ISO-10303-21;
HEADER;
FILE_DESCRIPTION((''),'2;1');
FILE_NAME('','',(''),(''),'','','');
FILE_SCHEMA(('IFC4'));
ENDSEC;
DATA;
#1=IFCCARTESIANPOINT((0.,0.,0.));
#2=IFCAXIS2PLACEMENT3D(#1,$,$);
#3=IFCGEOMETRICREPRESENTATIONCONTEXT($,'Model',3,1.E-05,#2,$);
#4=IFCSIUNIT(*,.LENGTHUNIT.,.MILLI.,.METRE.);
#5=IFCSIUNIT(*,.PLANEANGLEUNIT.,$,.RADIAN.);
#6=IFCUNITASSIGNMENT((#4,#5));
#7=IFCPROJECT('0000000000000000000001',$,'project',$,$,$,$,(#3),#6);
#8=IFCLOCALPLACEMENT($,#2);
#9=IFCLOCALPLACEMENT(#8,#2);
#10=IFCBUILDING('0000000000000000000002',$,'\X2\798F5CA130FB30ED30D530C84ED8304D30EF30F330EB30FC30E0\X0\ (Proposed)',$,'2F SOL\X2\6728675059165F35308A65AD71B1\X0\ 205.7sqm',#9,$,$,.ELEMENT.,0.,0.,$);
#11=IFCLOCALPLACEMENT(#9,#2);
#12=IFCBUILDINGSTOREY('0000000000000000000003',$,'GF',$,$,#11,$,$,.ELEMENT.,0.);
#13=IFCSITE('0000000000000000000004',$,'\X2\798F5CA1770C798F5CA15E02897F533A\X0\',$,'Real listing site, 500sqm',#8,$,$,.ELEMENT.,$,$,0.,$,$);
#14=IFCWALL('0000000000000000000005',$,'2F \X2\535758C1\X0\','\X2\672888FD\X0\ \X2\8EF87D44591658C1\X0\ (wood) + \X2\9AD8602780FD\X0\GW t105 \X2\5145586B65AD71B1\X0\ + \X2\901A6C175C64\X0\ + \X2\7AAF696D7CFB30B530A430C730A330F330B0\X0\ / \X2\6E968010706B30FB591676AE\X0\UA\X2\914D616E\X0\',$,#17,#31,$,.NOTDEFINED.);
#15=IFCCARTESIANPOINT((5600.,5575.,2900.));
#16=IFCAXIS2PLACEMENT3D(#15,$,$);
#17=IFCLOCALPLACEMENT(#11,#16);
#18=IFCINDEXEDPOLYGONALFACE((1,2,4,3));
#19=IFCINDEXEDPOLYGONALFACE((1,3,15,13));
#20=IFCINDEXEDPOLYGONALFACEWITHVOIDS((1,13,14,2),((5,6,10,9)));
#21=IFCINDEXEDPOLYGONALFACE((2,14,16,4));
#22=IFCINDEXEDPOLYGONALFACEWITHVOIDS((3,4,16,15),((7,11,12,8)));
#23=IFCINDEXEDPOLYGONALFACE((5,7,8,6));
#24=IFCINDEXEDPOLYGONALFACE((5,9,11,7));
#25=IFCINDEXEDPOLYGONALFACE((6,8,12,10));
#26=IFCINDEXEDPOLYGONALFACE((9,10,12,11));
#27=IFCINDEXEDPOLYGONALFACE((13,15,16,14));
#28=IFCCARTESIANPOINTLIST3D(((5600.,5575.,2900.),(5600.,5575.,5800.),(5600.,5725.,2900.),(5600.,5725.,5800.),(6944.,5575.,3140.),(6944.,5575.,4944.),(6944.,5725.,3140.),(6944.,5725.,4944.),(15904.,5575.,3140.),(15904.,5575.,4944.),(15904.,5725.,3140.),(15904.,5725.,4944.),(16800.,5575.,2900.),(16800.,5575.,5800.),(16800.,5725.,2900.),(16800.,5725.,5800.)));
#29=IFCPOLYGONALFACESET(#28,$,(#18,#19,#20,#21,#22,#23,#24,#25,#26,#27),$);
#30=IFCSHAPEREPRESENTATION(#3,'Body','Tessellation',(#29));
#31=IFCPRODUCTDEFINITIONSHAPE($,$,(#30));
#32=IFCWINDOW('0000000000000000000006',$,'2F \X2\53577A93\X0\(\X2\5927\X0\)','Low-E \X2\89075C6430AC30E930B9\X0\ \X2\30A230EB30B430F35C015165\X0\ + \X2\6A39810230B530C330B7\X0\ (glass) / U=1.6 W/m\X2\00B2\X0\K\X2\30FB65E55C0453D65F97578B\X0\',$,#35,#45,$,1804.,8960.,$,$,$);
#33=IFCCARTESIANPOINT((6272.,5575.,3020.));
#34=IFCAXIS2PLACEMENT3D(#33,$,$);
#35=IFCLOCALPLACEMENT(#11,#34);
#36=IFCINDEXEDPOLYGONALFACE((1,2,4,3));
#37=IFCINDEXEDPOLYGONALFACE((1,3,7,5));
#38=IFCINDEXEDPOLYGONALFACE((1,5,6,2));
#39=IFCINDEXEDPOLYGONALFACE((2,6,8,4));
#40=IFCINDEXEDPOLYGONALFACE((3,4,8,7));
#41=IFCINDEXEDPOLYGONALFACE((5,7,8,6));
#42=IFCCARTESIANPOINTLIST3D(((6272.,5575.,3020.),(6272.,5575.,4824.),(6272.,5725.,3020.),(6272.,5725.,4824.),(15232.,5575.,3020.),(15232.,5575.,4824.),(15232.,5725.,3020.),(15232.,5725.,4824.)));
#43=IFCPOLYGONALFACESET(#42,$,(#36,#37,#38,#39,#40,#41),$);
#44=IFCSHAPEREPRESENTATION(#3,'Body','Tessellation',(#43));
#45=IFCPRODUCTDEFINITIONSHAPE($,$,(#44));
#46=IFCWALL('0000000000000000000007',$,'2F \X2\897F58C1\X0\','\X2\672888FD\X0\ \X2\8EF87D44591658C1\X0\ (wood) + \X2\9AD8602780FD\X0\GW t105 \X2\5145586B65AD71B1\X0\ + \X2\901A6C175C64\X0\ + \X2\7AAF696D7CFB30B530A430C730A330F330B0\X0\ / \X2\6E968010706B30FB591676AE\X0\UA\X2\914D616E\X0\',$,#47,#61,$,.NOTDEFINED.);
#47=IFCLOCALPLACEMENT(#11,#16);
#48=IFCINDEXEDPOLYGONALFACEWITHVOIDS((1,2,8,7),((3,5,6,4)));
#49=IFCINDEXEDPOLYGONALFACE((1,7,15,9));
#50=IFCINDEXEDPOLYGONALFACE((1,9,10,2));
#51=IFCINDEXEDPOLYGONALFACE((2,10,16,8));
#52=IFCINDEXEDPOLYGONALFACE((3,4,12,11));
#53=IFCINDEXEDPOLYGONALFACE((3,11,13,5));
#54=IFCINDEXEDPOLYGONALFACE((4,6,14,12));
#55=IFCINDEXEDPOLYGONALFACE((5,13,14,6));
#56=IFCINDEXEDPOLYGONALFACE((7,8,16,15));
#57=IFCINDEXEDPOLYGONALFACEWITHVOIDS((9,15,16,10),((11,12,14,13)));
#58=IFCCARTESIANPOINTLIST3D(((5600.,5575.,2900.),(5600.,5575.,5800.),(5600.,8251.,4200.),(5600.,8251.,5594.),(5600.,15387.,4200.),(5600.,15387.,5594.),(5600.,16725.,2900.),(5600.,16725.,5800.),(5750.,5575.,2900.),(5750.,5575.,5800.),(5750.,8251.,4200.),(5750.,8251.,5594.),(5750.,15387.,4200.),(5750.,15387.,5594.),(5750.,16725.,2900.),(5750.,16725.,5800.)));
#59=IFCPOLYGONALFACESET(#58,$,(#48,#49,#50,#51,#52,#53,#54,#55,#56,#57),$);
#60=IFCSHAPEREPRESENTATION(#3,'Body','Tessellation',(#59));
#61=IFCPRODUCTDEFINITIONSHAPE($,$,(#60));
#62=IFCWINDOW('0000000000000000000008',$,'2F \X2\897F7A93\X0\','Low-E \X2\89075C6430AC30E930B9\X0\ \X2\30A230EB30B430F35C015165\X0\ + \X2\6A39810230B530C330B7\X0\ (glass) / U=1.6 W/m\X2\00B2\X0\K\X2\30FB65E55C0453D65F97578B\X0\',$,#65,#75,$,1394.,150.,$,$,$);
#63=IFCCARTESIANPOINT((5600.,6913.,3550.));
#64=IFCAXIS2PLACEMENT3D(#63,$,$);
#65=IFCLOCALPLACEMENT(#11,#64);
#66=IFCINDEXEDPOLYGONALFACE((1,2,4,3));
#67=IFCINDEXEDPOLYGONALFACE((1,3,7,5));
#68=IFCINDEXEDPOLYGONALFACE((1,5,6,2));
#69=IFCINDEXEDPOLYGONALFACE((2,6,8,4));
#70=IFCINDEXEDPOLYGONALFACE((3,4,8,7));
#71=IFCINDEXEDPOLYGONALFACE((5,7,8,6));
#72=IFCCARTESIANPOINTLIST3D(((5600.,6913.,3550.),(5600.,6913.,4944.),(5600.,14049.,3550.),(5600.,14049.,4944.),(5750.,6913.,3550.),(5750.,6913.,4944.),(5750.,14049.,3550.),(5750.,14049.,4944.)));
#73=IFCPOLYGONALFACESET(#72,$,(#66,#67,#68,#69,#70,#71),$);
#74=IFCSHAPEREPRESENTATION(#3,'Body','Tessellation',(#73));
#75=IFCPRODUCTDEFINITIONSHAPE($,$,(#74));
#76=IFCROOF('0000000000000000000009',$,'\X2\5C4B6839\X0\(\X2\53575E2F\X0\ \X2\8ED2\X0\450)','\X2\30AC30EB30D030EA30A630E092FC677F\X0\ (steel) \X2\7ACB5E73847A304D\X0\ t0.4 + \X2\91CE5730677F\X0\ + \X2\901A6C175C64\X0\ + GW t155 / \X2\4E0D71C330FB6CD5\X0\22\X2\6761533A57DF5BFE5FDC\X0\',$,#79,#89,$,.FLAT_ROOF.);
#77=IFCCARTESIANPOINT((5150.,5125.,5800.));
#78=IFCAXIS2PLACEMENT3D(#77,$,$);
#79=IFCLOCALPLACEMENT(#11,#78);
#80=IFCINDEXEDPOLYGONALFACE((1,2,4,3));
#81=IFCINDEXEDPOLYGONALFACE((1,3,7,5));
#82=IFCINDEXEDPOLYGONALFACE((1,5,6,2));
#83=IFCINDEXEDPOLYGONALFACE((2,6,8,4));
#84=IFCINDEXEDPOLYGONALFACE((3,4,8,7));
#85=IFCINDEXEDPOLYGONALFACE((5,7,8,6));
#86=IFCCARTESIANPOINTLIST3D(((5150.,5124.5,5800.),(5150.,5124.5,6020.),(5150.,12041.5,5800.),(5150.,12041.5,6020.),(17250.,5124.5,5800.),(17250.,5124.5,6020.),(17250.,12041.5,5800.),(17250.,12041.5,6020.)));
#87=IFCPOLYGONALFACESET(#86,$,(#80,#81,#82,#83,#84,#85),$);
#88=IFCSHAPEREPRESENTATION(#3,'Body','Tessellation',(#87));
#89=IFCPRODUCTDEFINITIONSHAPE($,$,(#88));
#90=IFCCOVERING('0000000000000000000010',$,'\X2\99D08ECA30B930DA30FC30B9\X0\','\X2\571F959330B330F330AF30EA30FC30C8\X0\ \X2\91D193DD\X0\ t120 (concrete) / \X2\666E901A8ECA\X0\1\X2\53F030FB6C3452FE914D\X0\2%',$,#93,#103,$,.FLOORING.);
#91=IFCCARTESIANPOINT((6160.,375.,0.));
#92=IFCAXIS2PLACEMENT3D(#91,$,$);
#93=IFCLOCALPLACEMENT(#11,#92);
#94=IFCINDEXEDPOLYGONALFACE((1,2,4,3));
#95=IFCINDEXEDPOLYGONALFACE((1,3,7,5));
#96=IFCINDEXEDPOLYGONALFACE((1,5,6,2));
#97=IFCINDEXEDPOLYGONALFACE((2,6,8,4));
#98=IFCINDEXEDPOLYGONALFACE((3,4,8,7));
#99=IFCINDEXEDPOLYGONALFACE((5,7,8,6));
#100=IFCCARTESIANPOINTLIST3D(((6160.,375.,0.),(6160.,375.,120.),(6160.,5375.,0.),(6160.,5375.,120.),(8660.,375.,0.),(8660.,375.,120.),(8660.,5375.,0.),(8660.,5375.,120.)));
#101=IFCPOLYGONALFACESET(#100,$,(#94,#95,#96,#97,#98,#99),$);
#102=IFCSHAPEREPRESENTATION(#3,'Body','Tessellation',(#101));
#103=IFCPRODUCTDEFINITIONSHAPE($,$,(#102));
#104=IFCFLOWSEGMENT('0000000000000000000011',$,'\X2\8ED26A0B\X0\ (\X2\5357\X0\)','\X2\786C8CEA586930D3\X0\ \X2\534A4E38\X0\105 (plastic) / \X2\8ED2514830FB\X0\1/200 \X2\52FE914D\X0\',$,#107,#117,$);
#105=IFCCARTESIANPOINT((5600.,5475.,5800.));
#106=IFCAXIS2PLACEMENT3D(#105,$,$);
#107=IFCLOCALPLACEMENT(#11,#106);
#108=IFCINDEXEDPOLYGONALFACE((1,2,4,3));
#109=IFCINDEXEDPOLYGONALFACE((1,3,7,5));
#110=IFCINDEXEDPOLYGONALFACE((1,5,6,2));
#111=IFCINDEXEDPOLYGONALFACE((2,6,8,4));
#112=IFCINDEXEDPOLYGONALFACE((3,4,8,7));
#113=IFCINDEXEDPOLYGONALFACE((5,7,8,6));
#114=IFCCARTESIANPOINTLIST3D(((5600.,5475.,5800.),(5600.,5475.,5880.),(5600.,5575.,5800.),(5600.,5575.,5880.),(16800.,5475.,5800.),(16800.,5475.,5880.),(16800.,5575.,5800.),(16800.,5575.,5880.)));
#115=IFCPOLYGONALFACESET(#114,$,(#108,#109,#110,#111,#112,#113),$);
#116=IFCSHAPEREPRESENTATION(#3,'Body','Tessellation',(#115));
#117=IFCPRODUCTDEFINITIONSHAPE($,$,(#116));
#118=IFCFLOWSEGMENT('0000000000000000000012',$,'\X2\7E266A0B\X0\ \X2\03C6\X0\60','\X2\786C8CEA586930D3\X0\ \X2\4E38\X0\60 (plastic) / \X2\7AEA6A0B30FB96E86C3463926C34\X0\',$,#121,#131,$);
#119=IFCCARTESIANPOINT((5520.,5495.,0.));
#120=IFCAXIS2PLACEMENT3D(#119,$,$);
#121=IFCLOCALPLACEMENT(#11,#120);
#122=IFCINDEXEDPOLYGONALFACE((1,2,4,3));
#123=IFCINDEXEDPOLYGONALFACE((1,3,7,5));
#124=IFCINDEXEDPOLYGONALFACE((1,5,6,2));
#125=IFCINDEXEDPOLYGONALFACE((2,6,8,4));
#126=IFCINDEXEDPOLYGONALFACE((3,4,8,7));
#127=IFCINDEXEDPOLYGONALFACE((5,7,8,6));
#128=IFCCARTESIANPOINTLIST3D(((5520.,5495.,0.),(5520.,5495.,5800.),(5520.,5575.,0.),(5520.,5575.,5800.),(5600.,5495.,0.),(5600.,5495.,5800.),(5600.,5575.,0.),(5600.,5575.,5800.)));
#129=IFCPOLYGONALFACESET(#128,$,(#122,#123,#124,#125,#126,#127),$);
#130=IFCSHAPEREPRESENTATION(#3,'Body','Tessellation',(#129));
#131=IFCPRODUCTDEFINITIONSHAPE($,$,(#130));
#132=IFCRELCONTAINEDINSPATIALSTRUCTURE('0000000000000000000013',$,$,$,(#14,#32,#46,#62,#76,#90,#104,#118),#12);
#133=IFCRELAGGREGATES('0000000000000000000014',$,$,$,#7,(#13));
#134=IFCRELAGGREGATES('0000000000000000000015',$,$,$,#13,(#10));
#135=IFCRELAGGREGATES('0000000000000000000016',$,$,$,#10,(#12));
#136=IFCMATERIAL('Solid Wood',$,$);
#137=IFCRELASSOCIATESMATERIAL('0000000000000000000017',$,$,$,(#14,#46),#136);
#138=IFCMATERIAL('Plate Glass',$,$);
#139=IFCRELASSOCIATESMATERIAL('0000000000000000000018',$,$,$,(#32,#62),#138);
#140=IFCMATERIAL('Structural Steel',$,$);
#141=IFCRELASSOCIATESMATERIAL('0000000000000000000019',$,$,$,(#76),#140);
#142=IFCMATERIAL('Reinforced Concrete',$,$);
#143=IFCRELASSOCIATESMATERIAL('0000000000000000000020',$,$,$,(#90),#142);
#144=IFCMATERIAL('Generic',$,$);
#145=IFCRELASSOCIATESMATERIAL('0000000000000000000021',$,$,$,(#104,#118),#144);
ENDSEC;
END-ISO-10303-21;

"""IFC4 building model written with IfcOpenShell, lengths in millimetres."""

from ifc_helpers import new_model, si_unit, frame, frame_2d, origin, place, context, project, spatial, rectangle, extrude, material, element, fill, save


model = new_model("IFC4")

# Units and contexts
model_context = context("Model", 3, precision=1e-05, world=origin())
ifc_project = project(units=[si_unit("LENGTHUNIT", "METRE", prefix="MILLI"), si_unit("PLANEANGLEUNIT", "RADIAN")], contexts=[model_context])

# Site, building, storey
site_placement = place(None, origin())
site = spatial("IfcSite", under=ifc_project, at=site_placement, Name="福岡県福岡市西区", ObjectType="Real listing site, 500sqm", CompositionType="ELEMENT", RefElevation=0.0)
building_placement = place(site_placement, origin())
building = spatial("IfcBuilding", under=site, at=building_placement, Name="福岡・ロフト付きワンルーム (Proposed)", ObjectType="2F SOL木材外張り断熱 205.7sqm", CompositionType="ELEMENT", ElevationOfRefHeight=0.0, ElevationOfTerrain=0.0)
storey_placement = place(building_placement, origin())
storey = spatial("IfcBuildingStorey", under=building, at=storey_placement, Name="GF", CompositionType="ELEMENT", Elevation=0.0)

# Shared definitions
ifc_material_1 = material(Name="Solid Wood")

# Shared definitions
ifc_material_2 = material(Name="Reinforced Concrete")

# Shared definitions
ifc_material_3 = material(Name="Plate Glass")

# Walls, openings, windows
wall_1_placement = place(storey_placement, frame((5600.0, 5575.0, 2900.0)))
wall_1 = element("IfcWall", 1, at=wall_1_placement, inside=storey, material=ifc_material_1, Name="2F 南壁", Description="木製 軸組外壁 (wood) + 高性能GW t105 充填断熱 + 通気層 + 窯業系サイディング / 準耐火・外皮UA配慮", PredefinedType="NOTDEFINED", context=model_context, shape_type="SweptSolid", body=[
    extrude(rectangle(XDim=11200.0, YDim=150.0, at=frame_2d((5600.0, 75.0))), frame((5600.0, 5575.0, 2900.0)), (0.0, 0.0, 1.0), 2900.0),
])
opening_1_placement = place(storey_placement, frame((6272.0, 5575.0, 3020.0)))
opening_1 = element("IfcOpeningElement", 2, at=opening_1_placement, cuts=wall_1, PredefinedType="NOTDEFINED", context=model_context, shape_type="SweptSolid", body=[
    extrude(rectangle(XDim=8960.0, YDim=150.0, at=frame_2d((4480.0, 75.0))), frame((6272.0, 5575.0, 3020.0)), (0.0, 0.0, 1.0), 1804.0),
])
window_1_placement = place(storey_placement, frame((6272.0, 5575.0, 3020.0)))
window_1 = element("IfcWindow", 3, at=window_1_placement, inside=storey, material=ifc_material_3, Name="2F 南窓(大)", Description="Low-E 複層ガラス アルゴン封入 + 樹脂サッシ (glass) / U=1.6 W/m²K・日射取得型", OverallHeight=1804.0, OverallWidth=8960.0, context=model_context, shape_type="SweptSolid", body=[
    extrude(rectangle(XDim=8960.0, YDim=150.0, at=frame_2d((4480.0, 75.0))), frame((6272.0, 5575.0, 3020.0)), (0.0, 0.0, 1.0), 1804.0),
])
fill(opening_1, window_1)
wall_2_placement = place(storey_placement, frame((5600.0, 5575.0, 2900.0)))
wall_2 = element("IfcWall", 4, at=wall_2_placement, inside=storey, material=ifc_material_1, Name="2F 西壁", Description="木製 軸組外壁 (wood) + 高性能GW t105 充填断熱 + 通気層 + 窯業系サイディング / 準耐火・外皮UA配慮", PredefinedType="NOTDEFINED", context=model_context, shape_type="SweptSolid", body=[
    extrude(rectangle(XDim=150.0, YDim=11150.0, at=frame_2d((75.0, 5575.0))), frame((5600.0, 5575.0, 2900.0)), (0.0, 0.0, 1.0), 2900.0),
])
opening_2_placement = place(storey_placement, frame((5600.0, 6913.0, 3550.0)))
opening_2 = element("IfcOpeningElement", 5, at=opening_2_placement, cuts=wall_2, PredefinedType="NOTDEFINED", context=model_context, shape_type="SweptSolid", body=[
    extrude(rectangle(XDim=150.0, YDim=7136.0, at=frame_2d((75.0, 3568.0))), frame((5600.0, 6913.0, 3550.0)), (0.0, 0.0, 1.0), 1394.0),
])
window_2_placement = place(storey_placement, frame((5600.0, 6913.0, 3550.0)))
window_2 = element("IfcWindow", 6, at=window_2_placement, inside=storey, material=ifc_material_3, Name="2F 西窓", Description="Low-E 複層ガラス アルゴン封入 + 樹脂サッシ (glass) / U=1.6 W/m²K・日射取得型", OverallHeight=1394.0, OverallWidth=150.0, context=model_context, shape_type="SweptSolid", body=[
    extrude(rectangle(XDim=150.0, YDim=7136.0, at=frame_2d((75.0, 3568.0))), frame((5600.0, 6913.0, 3550.0)), (0.0, 0.0, 1.0), 1394.0),
])
fill(opening_2, window_2)

# Roof
ifc_material_4 = material(Name="Structural Steel")
for number, where, name in (
    (7, (5150.0, 5125.0, 5800.0), "屋根(南帯 軒450)"),
):
    element("IfcRoof", number, at=place(storey_placement, frame(where)), inside=storey, material=ifc_material_4, Name=name, Description="ガルバリウム鋼板 (steel) 立平葺き t0.4 + 野地板 + 通気層 + GW t155 / 不燃・法22条区域対応", PredefinedType="FLAT_ROOF", context=model_context, shape_type="SweptSolid", body=[
        extrude(rectangle(XDim=12100.0, YDim=6917.0, at=frame_2d((6050.0, 3458.0))), frame((5150.0, 5125.0, 5800.0)), (0.0, 0.0, 1.0), 220.0),
    ])

# Covering
covering_placement = place(storey_placement, frame((6160.0, 375.0, 0.0)))
element("IfcCovering", 8, at=covering_placement, inside=storey, material=ifc_material_2, Name="駐車スペース", Description="土間コンクリート 金鏝 t120 (concrete) / 普通車1台・水勾配2%", PredefinedType="FLOORING", context=model_context, shape_type="SweptSolid", body=[
    extrude(rectangle(XDim=2500.0, YDim=5000.0, at=frame_2d((1250.0, 2500.0))), frame((6160.0, 375.0, 0.0)), (0.0, 0.0, 1.0), 120.0),
])

# Flow segments
ifc_material_5 = material(Name="Generic")
flow_segment_1_placement = place(storey_placement, frame((5600.0, 5475.0, 5800.0)))
element("IfcFlowSegment", 9, at=flow_segment_1_placement, inside=storey, material=ifc_material_5, Name="軒樋 (南)", Description="硬質塩ビ 半丸105 (plastic) / 軒先・1/200 勾配", context=model_context, shape_type="SweptSolid", body=[
    extrude(rectangle(XDim=11200.0, YDim=100.0, at=frame_2d((5600.0, 50.0))), frame((5600.0, 5475.0, 5800.0)), (0.0, 0.0, 1.0), 80.0),
])
flow_segment_2_placement = place(storey_placement, frame((5520.0, 5495.0, 0.0)))
element("IfcFlowSegment", 10, at=flow_segment_2_placement, inside=storey, material=ifc_material_5, Name="縦樋 φ60", Description="硬質塩ビ 丸60 (plastic) / 竪樋・雨水排水", context=model_context, shape_type="SweptSolid", body=[
    extrude(rectangle(XDim=80.0, YDim=80.0, at=frame_2d((40.0, 40.0))), frame((5520.0, 5495.0, 0.0)), (0.0, 0.0, 1.0), 5800.0),
])

save(model, "model.ifc")
